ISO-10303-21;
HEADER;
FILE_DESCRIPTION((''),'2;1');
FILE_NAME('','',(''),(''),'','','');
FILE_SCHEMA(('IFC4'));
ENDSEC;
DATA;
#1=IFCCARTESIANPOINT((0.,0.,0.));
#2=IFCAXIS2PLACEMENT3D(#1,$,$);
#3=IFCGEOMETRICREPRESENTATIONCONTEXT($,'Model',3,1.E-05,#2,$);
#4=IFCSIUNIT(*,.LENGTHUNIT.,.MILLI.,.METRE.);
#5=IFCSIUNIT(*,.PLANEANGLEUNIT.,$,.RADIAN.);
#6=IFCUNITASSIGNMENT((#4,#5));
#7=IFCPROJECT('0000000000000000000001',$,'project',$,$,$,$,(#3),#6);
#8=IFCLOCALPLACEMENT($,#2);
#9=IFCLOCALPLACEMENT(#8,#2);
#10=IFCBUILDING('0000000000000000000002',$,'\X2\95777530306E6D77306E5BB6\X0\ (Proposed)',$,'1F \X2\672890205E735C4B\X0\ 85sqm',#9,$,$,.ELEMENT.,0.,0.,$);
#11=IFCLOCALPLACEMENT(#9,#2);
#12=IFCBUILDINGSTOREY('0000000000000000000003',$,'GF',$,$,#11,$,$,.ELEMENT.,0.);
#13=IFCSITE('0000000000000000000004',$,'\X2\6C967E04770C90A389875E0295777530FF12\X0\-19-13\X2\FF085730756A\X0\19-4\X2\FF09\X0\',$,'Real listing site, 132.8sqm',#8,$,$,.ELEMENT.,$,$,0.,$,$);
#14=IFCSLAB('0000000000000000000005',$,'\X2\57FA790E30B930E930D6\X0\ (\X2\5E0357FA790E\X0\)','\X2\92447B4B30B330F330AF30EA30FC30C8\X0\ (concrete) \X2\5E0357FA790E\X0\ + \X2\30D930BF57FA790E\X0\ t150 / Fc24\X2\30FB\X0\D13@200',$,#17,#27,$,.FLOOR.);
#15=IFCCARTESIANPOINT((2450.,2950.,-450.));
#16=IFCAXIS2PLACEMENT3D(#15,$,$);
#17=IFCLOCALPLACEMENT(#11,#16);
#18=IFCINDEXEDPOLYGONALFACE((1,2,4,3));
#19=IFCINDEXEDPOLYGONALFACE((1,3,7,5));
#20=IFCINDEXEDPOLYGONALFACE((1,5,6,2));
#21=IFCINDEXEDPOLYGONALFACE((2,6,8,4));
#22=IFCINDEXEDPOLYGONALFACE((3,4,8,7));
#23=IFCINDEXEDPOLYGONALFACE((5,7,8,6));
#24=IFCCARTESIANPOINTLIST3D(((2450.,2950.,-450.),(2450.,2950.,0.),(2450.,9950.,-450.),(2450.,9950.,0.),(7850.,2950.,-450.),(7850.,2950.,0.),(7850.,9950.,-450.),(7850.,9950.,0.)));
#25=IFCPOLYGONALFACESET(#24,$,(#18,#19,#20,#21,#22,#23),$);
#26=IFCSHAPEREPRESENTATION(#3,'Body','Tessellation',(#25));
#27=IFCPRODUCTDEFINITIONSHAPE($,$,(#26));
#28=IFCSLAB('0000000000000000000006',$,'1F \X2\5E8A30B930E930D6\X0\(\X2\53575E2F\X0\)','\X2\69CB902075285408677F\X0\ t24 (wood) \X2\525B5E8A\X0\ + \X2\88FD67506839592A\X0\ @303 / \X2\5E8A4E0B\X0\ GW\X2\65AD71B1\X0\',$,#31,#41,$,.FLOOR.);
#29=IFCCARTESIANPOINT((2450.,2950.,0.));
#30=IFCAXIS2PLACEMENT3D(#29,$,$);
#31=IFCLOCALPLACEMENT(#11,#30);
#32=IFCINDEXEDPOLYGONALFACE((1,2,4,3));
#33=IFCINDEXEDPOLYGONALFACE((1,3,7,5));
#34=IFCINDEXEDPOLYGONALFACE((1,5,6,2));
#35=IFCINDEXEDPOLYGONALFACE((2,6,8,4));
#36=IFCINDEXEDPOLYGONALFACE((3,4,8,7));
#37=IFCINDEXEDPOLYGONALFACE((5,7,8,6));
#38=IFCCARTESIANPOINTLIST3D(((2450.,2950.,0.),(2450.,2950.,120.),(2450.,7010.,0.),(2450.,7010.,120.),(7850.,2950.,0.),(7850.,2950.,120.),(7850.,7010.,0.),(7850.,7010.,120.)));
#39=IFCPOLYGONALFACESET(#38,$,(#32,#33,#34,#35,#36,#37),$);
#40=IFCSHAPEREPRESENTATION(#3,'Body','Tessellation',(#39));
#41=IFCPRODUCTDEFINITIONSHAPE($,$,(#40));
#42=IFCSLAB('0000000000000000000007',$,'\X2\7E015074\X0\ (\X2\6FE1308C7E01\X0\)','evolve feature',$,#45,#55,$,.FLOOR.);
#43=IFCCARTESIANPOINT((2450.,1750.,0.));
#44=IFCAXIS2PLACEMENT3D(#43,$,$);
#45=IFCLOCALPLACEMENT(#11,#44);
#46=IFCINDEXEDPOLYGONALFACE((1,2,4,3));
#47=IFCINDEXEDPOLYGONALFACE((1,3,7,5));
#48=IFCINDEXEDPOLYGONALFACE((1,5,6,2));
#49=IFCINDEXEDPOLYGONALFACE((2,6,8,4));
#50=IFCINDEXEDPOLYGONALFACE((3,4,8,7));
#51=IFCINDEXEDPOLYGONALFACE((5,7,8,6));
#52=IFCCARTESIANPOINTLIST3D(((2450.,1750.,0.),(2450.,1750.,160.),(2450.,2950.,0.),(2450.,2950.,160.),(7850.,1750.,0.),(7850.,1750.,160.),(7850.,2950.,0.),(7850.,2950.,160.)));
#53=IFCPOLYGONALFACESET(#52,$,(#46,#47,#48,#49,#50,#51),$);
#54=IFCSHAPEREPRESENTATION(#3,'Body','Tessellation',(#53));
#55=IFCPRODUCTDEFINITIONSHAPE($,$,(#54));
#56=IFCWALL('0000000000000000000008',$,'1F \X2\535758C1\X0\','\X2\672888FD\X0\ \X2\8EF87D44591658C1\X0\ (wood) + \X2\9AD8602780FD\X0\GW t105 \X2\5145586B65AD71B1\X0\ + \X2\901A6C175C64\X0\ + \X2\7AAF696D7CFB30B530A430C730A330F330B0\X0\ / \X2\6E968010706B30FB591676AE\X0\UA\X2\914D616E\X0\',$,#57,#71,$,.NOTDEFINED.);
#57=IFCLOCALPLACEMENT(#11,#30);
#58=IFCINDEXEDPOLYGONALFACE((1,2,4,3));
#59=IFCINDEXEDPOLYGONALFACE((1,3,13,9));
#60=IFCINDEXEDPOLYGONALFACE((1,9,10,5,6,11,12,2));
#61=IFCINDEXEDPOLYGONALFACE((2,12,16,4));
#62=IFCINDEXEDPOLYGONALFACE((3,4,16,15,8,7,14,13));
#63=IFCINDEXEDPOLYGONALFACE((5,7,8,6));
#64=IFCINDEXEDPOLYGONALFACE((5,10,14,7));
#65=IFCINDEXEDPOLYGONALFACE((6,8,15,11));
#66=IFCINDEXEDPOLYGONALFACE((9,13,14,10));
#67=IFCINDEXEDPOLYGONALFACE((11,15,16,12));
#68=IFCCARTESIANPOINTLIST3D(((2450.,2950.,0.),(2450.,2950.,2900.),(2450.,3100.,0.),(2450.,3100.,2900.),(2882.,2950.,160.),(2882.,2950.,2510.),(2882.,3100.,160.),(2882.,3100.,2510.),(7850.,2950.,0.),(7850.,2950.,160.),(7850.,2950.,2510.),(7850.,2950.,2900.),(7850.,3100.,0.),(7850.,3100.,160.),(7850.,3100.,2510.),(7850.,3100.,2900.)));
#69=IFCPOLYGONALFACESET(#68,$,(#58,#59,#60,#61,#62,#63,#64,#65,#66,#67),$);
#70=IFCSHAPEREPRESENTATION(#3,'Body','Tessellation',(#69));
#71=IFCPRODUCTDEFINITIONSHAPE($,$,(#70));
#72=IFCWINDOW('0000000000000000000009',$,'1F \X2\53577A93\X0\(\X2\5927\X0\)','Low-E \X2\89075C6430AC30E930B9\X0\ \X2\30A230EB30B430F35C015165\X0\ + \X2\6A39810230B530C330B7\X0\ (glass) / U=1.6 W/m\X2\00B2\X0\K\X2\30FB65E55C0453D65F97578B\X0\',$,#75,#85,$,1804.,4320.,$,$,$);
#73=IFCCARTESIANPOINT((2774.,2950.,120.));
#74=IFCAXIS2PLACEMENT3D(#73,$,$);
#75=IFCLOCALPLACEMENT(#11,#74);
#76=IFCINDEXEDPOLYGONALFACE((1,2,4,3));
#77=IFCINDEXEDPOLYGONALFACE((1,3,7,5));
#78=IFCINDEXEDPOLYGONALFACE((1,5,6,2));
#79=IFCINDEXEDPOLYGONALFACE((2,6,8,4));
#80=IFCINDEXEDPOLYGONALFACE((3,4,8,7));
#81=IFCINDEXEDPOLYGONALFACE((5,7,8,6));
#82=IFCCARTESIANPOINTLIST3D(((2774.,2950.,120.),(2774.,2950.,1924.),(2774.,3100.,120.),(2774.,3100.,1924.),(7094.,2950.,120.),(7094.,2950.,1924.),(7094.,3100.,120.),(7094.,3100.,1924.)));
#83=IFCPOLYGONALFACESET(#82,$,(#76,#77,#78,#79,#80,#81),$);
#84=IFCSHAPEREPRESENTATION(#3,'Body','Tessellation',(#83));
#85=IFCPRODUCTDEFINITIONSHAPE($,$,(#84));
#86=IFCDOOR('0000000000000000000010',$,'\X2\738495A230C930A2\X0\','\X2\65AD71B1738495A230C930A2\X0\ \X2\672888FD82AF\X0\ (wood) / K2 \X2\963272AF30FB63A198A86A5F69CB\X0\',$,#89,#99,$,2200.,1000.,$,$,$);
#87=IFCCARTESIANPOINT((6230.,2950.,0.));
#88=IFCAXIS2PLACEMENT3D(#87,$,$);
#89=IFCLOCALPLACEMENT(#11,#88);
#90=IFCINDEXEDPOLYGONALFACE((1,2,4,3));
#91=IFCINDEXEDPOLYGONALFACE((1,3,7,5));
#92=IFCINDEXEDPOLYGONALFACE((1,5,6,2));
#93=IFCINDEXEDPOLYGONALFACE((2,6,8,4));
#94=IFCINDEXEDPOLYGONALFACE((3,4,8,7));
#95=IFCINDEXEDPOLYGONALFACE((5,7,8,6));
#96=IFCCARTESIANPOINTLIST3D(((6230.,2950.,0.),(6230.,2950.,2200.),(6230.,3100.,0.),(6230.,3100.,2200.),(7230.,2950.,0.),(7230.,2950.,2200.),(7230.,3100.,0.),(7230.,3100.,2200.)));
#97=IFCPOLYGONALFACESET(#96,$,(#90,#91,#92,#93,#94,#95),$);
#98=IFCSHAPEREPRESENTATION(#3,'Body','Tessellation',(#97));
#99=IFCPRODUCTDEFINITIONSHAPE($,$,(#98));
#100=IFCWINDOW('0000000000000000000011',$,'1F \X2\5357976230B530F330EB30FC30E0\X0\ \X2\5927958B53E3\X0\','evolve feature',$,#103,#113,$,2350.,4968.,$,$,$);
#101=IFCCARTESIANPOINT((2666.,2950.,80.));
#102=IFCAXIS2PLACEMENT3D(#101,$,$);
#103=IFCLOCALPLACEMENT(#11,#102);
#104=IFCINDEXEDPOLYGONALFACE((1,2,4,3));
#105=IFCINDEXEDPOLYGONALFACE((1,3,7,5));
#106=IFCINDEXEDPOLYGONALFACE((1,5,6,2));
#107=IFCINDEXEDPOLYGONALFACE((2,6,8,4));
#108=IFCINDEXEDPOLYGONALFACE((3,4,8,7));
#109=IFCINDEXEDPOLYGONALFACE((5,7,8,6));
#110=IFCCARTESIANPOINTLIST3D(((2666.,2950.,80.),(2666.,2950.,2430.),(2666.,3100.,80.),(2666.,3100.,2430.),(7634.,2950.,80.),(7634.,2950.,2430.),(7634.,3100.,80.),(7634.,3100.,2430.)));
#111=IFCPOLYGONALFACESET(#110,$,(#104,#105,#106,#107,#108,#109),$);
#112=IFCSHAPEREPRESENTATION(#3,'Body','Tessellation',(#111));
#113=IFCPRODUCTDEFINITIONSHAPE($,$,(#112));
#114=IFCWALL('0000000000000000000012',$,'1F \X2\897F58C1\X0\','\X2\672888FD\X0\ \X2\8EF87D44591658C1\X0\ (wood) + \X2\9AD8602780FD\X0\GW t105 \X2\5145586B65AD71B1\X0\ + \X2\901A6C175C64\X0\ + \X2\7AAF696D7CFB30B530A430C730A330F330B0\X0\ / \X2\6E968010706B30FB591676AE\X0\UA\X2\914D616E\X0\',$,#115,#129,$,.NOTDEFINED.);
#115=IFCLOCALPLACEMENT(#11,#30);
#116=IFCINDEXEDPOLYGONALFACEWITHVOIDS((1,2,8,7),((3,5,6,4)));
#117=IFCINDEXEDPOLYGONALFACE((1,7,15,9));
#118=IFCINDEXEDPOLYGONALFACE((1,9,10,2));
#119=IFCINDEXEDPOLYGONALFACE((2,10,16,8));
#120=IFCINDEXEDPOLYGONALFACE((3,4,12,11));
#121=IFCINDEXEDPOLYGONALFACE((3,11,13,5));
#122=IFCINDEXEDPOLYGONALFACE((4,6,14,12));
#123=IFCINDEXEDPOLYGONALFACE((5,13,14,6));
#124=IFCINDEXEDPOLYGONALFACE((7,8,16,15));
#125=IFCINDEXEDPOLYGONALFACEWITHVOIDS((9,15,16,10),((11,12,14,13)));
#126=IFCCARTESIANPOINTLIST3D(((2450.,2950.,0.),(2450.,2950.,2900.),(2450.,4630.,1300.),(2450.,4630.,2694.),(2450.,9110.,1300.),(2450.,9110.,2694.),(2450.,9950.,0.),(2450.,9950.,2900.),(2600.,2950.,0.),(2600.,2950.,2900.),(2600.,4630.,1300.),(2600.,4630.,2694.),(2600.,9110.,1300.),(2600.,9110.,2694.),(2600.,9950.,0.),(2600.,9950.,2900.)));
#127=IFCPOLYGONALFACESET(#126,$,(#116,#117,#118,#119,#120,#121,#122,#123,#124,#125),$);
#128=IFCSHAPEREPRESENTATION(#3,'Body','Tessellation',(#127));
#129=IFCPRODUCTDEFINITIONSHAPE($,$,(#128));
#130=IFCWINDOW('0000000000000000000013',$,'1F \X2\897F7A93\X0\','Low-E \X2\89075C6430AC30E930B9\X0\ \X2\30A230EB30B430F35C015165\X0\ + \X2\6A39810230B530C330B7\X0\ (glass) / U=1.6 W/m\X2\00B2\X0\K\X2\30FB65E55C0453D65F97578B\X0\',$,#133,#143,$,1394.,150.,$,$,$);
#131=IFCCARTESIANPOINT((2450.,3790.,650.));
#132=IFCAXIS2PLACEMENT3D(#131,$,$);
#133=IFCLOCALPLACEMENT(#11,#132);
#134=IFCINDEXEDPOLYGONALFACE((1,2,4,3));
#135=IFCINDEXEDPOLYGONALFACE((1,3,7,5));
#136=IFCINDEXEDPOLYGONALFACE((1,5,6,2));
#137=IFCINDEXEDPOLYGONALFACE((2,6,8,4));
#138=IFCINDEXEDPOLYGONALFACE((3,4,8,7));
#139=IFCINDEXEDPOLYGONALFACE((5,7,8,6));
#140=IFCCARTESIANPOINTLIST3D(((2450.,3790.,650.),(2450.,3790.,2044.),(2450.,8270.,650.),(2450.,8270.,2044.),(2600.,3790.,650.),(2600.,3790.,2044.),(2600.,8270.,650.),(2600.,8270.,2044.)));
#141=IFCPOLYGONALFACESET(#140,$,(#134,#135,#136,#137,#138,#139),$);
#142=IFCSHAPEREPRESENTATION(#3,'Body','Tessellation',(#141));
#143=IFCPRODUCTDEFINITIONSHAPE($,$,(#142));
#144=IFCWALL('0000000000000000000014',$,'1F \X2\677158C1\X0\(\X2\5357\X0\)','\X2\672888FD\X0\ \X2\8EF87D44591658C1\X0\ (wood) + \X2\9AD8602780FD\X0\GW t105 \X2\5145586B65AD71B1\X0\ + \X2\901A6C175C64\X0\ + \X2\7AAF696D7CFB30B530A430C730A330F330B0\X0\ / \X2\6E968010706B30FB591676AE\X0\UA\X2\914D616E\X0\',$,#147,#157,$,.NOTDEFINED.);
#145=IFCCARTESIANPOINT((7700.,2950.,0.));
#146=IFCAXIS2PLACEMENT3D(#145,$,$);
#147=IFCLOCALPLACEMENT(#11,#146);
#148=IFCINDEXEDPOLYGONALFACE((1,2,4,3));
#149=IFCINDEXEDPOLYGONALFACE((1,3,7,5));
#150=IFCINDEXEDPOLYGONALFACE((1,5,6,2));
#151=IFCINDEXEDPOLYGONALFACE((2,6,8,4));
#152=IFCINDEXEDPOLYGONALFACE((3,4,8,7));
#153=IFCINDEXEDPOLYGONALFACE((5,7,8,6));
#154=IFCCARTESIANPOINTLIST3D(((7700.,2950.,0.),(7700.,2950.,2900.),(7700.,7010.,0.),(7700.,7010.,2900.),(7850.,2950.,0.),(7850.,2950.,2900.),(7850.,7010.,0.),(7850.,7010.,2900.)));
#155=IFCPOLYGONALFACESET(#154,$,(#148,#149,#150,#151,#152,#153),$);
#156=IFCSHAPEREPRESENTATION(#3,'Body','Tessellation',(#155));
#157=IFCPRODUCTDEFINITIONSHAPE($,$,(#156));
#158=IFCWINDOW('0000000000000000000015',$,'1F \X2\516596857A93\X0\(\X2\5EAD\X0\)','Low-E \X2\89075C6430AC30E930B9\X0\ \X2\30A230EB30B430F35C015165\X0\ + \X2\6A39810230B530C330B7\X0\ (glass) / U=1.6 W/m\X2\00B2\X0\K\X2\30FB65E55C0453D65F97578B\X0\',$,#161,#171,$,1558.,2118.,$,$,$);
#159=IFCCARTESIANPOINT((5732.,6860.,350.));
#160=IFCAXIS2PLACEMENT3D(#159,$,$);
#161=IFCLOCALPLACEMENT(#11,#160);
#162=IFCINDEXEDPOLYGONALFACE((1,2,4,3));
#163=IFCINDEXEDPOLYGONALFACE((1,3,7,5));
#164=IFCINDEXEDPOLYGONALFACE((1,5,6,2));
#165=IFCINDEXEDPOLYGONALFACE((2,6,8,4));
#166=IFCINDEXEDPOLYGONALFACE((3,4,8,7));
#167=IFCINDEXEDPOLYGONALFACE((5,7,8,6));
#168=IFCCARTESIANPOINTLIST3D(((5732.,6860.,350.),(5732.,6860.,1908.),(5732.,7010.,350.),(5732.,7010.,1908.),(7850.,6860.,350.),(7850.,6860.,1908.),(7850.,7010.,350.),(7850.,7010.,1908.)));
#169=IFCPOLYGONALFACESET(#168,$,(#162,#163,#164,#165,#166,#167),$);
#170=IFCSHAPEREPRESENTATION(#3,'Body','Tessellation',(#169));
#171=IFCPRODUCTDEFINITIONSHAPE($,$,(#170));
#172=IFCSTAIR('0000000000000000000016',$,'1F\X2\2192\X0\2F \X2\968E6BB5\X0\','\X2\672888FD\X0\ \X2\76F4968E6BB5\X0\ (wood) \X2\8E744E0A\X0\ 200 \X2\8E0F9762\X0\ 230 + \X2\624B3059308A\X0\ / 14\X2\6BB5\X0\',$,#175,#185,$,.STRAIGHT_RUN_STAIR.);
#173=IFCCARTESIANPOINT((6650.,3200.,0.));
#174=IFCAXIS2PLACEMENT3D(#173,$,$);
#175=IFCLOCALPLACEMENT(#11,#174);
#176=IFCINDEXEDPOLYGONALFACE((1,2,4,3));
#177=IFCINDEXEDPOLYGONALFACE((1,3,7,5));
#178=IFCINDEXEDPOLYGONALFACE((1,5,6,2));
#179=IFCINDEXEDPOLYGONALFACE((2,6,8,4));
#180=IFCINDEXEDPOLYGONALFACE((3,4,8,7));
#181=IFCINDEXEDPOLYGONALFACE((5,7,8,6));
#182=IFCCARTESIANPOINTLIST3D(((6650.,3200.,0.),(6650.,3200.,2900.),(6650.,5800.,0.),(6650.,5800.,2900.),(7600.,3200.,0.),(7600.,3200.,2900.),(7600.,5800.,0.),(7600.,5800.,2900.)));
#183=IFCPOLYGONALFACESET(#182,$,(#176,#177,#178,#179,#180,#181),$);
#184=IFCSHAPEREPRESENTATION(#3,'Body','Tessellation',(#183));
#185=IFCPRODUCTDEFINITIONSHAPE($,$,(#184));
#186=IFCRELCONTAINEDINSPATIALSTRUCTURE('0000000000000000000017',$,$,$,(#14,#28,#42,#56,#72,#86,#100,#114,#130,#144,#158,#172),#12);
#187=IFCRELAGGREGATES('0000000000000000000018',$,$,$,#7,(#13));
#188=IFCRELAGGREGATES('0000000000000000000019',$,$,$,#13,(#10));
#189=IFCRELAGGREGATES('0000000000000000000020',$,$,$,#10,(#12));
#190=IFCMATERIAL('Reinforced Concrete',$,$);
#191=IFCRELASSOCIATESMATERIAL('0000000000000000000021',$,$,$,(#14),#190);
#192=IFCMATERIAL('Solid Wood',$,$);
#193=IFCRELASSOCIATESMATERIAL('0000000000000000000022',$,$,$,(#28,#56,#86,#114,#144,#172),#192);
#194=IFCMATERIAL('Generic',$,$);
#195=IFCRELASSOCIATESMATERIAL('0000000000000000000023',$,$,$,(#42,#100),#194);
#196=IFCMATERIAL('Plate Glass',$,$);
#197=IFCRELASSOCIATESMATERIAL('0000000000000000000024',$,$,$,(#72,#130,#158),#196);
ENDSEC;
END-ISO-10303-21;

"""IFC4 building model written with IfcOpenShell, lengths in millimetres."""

from ifc_helpers import new_model, si_unit, frame, frame_2d, origin, place, context, project, spatial, rectangle, extrude, material, element, fill, save


model = new_model("IFC4")

# Units and contexts
model_context = context("Model", 3, precision=1e-05, world=origin())
ifc_project = project(units=[si_unit("LENGTHUNIT", "METRE", prefix="MILLI"), si_unit("PLANEANGLEUNIT", "RADIAN")], contexts=[model_context])

# Site, building, storey
site_placement = place(None, origin())
site = spatial("IfcSite", under=ifc_project, at=site_placement, Name="沖縄県那覇市長田２-19-13（地番19-4）", ObjectType="Real listing site, 132.8sqm", CompositionType="ELEMENT", RefElevation=0.0)
building_placement = place(site_placement, origin())
building = spatial("IfcBuilding", under=site, at=building_placement, Name="長田の海の家 (Proposed)", ObjectType="1F 木造平屋 85sqm", CompositionType="ELEMENT", ElevationOfRefHeight=0.0, ElevationOfTerrain=0.0)
storey_placement = place(building_placement, origin())
storey = spatial("IfcBuildingStorey", under=building, at=storey_placement, Name="GF", CompositionType="ELEMENT", Elevation=0.0)

# Slabs
ifc_material_1 = material(Name="Reinforced Concrete")
slab_1_placement = place(storey_placement, frame((2450.0, 2950.0, -450.0)))
element("IfcSlab", 1, at=slab_1_placement, inside=storey, material=ifc_material_1, Name="基礎スラブ (布基礎)", Description="鉄筋コンクリート (concrete) 布基礎 + ベタ基礎 t150 / Fc24・D13@200", PredefinedType="FLOOR", context=model_context, shape_type="SweptSolid", body=[
    extrude(rectangle(XDim=5400.0, YDim=7000.0, at=frame_2d((2700.0, 3500.0))), frame((2450.0, 2950.0, -450.0)), (0.0, 0.0, 1.0), 450.0),
])
ifc_material_2 = material(Name="Solid Wood")
slab_2_placement = place(storey_placement, frame((2450.0, 2950.0, 0.0)))
element("IfcSlab", 2, at=slab_2_placement, inside=storey, material=ifc_material_2, Name="1F 床スラブ(南帯)", Description="構造用合板 t24 (wood) 剛床 + 製材根太 @303 / 床下 GW断熱", PredefinedType="FLOOR", context=model_context, shape_type="SweptSolid", body=[
    extrude(rectangle(XDim=5400.0, YDim=4060.0, at=frame_2d((2700.0, 2030.0))), frame((2450.0, 2950.0, 0.0)), (0.0, 0.0, 1.0), 120.0),
])
ifc_material_3 = material(Name="Generic")
slab_3_placement = place(storey_placement, frame((2450.0, 1750.0, 0.0)))
element("IfcSlab", 3, at=slab_3_placement, inside=storey, material=ifc_material_3, Name="縁側 (濡れ縁)", Description="evolve feature", PredefinedType="FLOOR", context=model_context, shape_type="SweptSolid", body=[
    extrude(rectangle(XDim=5400.0, YDim=1200.0, at=frame_2d((2700.0, 600.0))), frame((2450.0, 1750.0, 0.0)), (0.0, 0.0, 1.0), 160.0),
])

# Wall, openings, windows, door
wall_1_placement = place(storey_placement, frame((2450.0, 2950.0, 0.0)))
wall_1 = element("IfcWall", 4, at=wall_1_placement, inside=storey, material=ifc_material_2, Name="1F 南壁", Description="木製 軸組外壁 (wood) + 高性能GW t105 充填断熱 + 通気層 + 窯業系サイディング / 準耐火・外皮UA配慮", PredefinedType="NOTDEFINED", context=model_context, shape_type="SweptSolid", body=[
    extrude(rectangle(XDim=5400.0, YDim=150.0, at=frame_2d((2700.0, 75.0))), frame((2450.0, 2950.0, 0.0)), (0.0, 0.0, 1.0), 2900.0),
])
opening_1_placement = place(storey_placement, frame((2774.0, 2950.0, 120.0)))
opening_1 = element("IfcOpeningElement", 5, at=opening_1_placement, cuts=wall_1, PredefinedType="NOTDEFINED", context=model_context, shape_type="SweptSolid", body=[
    extrude(rectangle(XDim=4320.0, YDim=150.0, at=frame_2d((2160.0, 75.0))), frame((2774.0, 2950.0, 120.0)), (0.0, 0.0, 1.0), 1804.0),
])
opening_2_placement = place(storey_placement, frame((6230.0, 2950.0, 0.0)))
opening_2 = element("IfcOpeningElement", 6, at=opening_2_placement, cuts=wall_1, PredefinedType="NOTDEFINED", context=model_context, shape_type="SweptSolid", body=[
    extrude(rectangle(XDim=1000.0, YDim=150.0, at=frame_2d((500.0, 75.0))), frame((6230.0, 2950.0, 0.0)), (0.0, 0.0, 1.0), 2200.0),
])
opening_3_placement = place(storey_placement, frame((2666.0, 2950.0, 80.0)))
opening_3 = element("IfcOpeningElement", 7, at=opening_3_placement, cuts=wall_1, PredefinedType="NOTDEFINED", context=model_context, shape_type="SweptSolid", body=[
    extrude(rectangle(XDim=4968.0, YDim=150.0, at=frame_2d((2484.0, 75.0))), frame((2666.0, 2950.0, 80.0)), (0.0, 0.0, 1.0), 2350.0),
])
ifc_material_4 = material(Name="Plate Glass")
window_1_placement = place(storey_placement, frame((2774.0, 2950.0, 120.0)))
window_1 = element("IfcWindow", 8, at=window_1_placement, inside=storey, material=ifc_material_4, Name="1F 南窓(大)", Description="Low-E 複層ガラス アルゴン封入 + 樹脂サッシ (glass) / U=1.6 W/m²K・日射取得型", OverallHeight=1804.0, OverallWidth=4320.0, context=model_context, shape_type="SweptSolid", body=[
    extrude(rectangle(XDim=4320.0, YDim=150.0, at=frame_2d((2160.0, 75.0))), frame((2774.0, 2950.0, 120.0)), (0.0, 0.0, 1.0), 1804.0),
])
fill(opening_1, window_1)
door_1_placement = place(storey_placement, frame((6230.0, 2950.0, 0.0)))
door_1 = element("IfcDoor", 9, at=door_1_placement, inside=storey, material=ifc_material_2, Name="玄関ドア", Description="断熱玄関ドア 木製芯 (wood) / K2 防犯・採風機構", OverallHeight=2200.0, OverallWidth=1000.0, context=model_context, shape_type="SweptSolid", body=[
    extrude(rectangle(XDim=1000.0, YDim=150.0, at=frame_2d((500.0, 75.0))), frame((6230.0, 2950.0, 0.0)), (0.0, 0.0, 1.0), 2200.0),
])
fill(opening_2, door_1)
window_2_placement = place(storey_placement, frame((2666.0, 2950.0, 80.0)))
window_2 = element("IfcWindow", 10, at=window_2_placement, inside=storey, material=ifc_material_3, Name="1F 南面サンルーム 大開口", Description="evolve feature", OverallHeight=2350.0, OverallWidth=4968.0, context=model_context, shape_type="SweptSolid", body=[
    extrude(rectangle(XDim=4968.0, YDim=150.0, at=frame_2d((2484.0, 75.0))), frame((2666.0, 2950.0, 80.0)), (0.0, 0.0, 1.0), 2350.0),
])
fill(opening_3, window_2)

# Walls, openings, windows
wall_2_placement = place(storey_placement, frame((2450.0, 2950.0, 0.0)))
wall_2 = element("IfcWall", 11, at=wall_2_placement, inside=storey, material=ifc_material_2, Name="1F 西壁", Description="木製 軸組外壁 (wood) + 高性能GW t105 充填断熱 + 通気層 + 窯業系サイディング / 準耐火・外皮UA配慮", PredefinedType="NOTDEFINED", context=model_context, shape_type="SweptSolid", body=[
    extrude(rectangle(XDim=150.0, YDim=7000.0, at=frame_2d((75.0, 3500.0))), frame((2450.0, 2950.0, 0.0)), (0.0, 0.0, 1.0), 2900.0),
])
opening_4_placement = place(storey_placement, frame((2450.0, 3790.0, 650.0)))
opening_4 = element("IfcOpeningElement", 12, at=opening_4_placement, cuts=wall_2, PredefinedType="NOTDEFINED", context=model_context, shape_type="SweptSolid", body=[
    extrude(rectangle(XDim=150.0, YDim=4480.0, at=frame_2d((75.0, 2240.0))), frame((2450.0, 3790.0, 650.0)), (0.0, 0.0, 1.0), 1394.0),
])
window_3_placement = place(storey_placement, frame((2450.0, 3790.0, 650.0)))
window_3 = element("IfcWindow", 13, at=window_3_placement, inside=storey, material=ifc_material_4, Name="1F 西窓", Description="Low-E 複層ガラス アルゴン封入 + 樹脂サッシ (glass) / U=1.6 W/m²K・日射取得型", OverallHeight=1394.0, OverallWidth=150.0, context=model_context, shape_type="SweptSolid", body=[
    extrude(rectangle(XDim=150.0, YDim=4480.0, at=frame_2d((75.0, 2240.0))), frame((2450.0, 3790.0, 650.0)), (0.0, 0.0, 1.0), 1394.0),
])
fill(opening_4, window_3)
wall_3_placement = place(storey_placement, frame((7700.0, 2950.0, 0.0)))
wall_3 = element("IfcWall", 14, at=wall_3_placement, inside=storey, material=ifc_material_2, Name="1F 東壁(南)", Description="木製 軸組外壁 (wood) + 高性能GW t105 充填断熱 + 通気層 + 窯業系サイディング / 準耐火・外皮UA配慮", PredefinedType="NOTDEFINED", context=model_context, shape_type="SweptSolid", body=[
    extrude(rectangle(XDim=150.0, YDim=4060.0, at=frame_2d((75.0, 2030.0))), frame((7700.0, 2950.0, 0.0)), (0.0, 0.0, 1.0), 2900.0),
])
opening_5_placement = place(storey_placement, frame((5732.0, 6860.0, 350.0)))
opening_5 = element("IfcOpeningElement", 15, at=opening_5_placement, cuts=wall_3, PredefinedType="NOTDEFINED", context=model_context, shape_type="SweptSolid", body=[
    extrude(rectangle(XDim=2118.0, YDim=150.0, at=frame_2d((1059.0, 75.0))), frame((5732.0, 6860.0, 350.0)), (0.0, 0.0, 1.0), 1558.0),
])
window_4_placement = place(storey_placement, frame((5732.0, 6860.0, 350.0)))
window_4 = element("IfcWindow", 16, at=window_4_placement, inside=storey, material=ifc_material_4, Name="1F 入隅窓(庭)", Description="Low-E 複層ガラス アルゴン封入 + 樹脂サッシ (glass) / U=1.6 W/m²K・日射取得型", OverallHeight=1558.0, OverallWidth=2118.0, context=model_context, shape_type="SweptSolid", body=[
    extrude(rectangle(XDim=2118.0, YDim=150.0, at=frame_2d((1059.0, 75.0))), frame((5732.0, 6860.0, 350.0)), (0.0, 0.0, 1.0), 1558.0),
])
fill(opening_5, window_4)

# Stair
stair_placement = place(storey_placement, frame((6650.0, 3200.0, 0.0)))
element("IfcStair", 17, at=stair_placement, inside=storey, material=ifc_material_2, Name="1F→2F 階段", Description="木製 直階段 (wood) 蹴上 200 踏面 230 + 手すり / 14段", PredefinedType="STRAIGHT_RUN_STAIR", context=model_context, shape_type="SweptSolid", body=[
    extrude(rectangle(XDim=950.0, YDim=2600.0, at=frame_2d((475.0, 1300.0))), frame((6650.0, 3200.0, 0.0)), (0.0, 0.0, 1.0), 2900.0),
])

save(model, "model.ifc")
